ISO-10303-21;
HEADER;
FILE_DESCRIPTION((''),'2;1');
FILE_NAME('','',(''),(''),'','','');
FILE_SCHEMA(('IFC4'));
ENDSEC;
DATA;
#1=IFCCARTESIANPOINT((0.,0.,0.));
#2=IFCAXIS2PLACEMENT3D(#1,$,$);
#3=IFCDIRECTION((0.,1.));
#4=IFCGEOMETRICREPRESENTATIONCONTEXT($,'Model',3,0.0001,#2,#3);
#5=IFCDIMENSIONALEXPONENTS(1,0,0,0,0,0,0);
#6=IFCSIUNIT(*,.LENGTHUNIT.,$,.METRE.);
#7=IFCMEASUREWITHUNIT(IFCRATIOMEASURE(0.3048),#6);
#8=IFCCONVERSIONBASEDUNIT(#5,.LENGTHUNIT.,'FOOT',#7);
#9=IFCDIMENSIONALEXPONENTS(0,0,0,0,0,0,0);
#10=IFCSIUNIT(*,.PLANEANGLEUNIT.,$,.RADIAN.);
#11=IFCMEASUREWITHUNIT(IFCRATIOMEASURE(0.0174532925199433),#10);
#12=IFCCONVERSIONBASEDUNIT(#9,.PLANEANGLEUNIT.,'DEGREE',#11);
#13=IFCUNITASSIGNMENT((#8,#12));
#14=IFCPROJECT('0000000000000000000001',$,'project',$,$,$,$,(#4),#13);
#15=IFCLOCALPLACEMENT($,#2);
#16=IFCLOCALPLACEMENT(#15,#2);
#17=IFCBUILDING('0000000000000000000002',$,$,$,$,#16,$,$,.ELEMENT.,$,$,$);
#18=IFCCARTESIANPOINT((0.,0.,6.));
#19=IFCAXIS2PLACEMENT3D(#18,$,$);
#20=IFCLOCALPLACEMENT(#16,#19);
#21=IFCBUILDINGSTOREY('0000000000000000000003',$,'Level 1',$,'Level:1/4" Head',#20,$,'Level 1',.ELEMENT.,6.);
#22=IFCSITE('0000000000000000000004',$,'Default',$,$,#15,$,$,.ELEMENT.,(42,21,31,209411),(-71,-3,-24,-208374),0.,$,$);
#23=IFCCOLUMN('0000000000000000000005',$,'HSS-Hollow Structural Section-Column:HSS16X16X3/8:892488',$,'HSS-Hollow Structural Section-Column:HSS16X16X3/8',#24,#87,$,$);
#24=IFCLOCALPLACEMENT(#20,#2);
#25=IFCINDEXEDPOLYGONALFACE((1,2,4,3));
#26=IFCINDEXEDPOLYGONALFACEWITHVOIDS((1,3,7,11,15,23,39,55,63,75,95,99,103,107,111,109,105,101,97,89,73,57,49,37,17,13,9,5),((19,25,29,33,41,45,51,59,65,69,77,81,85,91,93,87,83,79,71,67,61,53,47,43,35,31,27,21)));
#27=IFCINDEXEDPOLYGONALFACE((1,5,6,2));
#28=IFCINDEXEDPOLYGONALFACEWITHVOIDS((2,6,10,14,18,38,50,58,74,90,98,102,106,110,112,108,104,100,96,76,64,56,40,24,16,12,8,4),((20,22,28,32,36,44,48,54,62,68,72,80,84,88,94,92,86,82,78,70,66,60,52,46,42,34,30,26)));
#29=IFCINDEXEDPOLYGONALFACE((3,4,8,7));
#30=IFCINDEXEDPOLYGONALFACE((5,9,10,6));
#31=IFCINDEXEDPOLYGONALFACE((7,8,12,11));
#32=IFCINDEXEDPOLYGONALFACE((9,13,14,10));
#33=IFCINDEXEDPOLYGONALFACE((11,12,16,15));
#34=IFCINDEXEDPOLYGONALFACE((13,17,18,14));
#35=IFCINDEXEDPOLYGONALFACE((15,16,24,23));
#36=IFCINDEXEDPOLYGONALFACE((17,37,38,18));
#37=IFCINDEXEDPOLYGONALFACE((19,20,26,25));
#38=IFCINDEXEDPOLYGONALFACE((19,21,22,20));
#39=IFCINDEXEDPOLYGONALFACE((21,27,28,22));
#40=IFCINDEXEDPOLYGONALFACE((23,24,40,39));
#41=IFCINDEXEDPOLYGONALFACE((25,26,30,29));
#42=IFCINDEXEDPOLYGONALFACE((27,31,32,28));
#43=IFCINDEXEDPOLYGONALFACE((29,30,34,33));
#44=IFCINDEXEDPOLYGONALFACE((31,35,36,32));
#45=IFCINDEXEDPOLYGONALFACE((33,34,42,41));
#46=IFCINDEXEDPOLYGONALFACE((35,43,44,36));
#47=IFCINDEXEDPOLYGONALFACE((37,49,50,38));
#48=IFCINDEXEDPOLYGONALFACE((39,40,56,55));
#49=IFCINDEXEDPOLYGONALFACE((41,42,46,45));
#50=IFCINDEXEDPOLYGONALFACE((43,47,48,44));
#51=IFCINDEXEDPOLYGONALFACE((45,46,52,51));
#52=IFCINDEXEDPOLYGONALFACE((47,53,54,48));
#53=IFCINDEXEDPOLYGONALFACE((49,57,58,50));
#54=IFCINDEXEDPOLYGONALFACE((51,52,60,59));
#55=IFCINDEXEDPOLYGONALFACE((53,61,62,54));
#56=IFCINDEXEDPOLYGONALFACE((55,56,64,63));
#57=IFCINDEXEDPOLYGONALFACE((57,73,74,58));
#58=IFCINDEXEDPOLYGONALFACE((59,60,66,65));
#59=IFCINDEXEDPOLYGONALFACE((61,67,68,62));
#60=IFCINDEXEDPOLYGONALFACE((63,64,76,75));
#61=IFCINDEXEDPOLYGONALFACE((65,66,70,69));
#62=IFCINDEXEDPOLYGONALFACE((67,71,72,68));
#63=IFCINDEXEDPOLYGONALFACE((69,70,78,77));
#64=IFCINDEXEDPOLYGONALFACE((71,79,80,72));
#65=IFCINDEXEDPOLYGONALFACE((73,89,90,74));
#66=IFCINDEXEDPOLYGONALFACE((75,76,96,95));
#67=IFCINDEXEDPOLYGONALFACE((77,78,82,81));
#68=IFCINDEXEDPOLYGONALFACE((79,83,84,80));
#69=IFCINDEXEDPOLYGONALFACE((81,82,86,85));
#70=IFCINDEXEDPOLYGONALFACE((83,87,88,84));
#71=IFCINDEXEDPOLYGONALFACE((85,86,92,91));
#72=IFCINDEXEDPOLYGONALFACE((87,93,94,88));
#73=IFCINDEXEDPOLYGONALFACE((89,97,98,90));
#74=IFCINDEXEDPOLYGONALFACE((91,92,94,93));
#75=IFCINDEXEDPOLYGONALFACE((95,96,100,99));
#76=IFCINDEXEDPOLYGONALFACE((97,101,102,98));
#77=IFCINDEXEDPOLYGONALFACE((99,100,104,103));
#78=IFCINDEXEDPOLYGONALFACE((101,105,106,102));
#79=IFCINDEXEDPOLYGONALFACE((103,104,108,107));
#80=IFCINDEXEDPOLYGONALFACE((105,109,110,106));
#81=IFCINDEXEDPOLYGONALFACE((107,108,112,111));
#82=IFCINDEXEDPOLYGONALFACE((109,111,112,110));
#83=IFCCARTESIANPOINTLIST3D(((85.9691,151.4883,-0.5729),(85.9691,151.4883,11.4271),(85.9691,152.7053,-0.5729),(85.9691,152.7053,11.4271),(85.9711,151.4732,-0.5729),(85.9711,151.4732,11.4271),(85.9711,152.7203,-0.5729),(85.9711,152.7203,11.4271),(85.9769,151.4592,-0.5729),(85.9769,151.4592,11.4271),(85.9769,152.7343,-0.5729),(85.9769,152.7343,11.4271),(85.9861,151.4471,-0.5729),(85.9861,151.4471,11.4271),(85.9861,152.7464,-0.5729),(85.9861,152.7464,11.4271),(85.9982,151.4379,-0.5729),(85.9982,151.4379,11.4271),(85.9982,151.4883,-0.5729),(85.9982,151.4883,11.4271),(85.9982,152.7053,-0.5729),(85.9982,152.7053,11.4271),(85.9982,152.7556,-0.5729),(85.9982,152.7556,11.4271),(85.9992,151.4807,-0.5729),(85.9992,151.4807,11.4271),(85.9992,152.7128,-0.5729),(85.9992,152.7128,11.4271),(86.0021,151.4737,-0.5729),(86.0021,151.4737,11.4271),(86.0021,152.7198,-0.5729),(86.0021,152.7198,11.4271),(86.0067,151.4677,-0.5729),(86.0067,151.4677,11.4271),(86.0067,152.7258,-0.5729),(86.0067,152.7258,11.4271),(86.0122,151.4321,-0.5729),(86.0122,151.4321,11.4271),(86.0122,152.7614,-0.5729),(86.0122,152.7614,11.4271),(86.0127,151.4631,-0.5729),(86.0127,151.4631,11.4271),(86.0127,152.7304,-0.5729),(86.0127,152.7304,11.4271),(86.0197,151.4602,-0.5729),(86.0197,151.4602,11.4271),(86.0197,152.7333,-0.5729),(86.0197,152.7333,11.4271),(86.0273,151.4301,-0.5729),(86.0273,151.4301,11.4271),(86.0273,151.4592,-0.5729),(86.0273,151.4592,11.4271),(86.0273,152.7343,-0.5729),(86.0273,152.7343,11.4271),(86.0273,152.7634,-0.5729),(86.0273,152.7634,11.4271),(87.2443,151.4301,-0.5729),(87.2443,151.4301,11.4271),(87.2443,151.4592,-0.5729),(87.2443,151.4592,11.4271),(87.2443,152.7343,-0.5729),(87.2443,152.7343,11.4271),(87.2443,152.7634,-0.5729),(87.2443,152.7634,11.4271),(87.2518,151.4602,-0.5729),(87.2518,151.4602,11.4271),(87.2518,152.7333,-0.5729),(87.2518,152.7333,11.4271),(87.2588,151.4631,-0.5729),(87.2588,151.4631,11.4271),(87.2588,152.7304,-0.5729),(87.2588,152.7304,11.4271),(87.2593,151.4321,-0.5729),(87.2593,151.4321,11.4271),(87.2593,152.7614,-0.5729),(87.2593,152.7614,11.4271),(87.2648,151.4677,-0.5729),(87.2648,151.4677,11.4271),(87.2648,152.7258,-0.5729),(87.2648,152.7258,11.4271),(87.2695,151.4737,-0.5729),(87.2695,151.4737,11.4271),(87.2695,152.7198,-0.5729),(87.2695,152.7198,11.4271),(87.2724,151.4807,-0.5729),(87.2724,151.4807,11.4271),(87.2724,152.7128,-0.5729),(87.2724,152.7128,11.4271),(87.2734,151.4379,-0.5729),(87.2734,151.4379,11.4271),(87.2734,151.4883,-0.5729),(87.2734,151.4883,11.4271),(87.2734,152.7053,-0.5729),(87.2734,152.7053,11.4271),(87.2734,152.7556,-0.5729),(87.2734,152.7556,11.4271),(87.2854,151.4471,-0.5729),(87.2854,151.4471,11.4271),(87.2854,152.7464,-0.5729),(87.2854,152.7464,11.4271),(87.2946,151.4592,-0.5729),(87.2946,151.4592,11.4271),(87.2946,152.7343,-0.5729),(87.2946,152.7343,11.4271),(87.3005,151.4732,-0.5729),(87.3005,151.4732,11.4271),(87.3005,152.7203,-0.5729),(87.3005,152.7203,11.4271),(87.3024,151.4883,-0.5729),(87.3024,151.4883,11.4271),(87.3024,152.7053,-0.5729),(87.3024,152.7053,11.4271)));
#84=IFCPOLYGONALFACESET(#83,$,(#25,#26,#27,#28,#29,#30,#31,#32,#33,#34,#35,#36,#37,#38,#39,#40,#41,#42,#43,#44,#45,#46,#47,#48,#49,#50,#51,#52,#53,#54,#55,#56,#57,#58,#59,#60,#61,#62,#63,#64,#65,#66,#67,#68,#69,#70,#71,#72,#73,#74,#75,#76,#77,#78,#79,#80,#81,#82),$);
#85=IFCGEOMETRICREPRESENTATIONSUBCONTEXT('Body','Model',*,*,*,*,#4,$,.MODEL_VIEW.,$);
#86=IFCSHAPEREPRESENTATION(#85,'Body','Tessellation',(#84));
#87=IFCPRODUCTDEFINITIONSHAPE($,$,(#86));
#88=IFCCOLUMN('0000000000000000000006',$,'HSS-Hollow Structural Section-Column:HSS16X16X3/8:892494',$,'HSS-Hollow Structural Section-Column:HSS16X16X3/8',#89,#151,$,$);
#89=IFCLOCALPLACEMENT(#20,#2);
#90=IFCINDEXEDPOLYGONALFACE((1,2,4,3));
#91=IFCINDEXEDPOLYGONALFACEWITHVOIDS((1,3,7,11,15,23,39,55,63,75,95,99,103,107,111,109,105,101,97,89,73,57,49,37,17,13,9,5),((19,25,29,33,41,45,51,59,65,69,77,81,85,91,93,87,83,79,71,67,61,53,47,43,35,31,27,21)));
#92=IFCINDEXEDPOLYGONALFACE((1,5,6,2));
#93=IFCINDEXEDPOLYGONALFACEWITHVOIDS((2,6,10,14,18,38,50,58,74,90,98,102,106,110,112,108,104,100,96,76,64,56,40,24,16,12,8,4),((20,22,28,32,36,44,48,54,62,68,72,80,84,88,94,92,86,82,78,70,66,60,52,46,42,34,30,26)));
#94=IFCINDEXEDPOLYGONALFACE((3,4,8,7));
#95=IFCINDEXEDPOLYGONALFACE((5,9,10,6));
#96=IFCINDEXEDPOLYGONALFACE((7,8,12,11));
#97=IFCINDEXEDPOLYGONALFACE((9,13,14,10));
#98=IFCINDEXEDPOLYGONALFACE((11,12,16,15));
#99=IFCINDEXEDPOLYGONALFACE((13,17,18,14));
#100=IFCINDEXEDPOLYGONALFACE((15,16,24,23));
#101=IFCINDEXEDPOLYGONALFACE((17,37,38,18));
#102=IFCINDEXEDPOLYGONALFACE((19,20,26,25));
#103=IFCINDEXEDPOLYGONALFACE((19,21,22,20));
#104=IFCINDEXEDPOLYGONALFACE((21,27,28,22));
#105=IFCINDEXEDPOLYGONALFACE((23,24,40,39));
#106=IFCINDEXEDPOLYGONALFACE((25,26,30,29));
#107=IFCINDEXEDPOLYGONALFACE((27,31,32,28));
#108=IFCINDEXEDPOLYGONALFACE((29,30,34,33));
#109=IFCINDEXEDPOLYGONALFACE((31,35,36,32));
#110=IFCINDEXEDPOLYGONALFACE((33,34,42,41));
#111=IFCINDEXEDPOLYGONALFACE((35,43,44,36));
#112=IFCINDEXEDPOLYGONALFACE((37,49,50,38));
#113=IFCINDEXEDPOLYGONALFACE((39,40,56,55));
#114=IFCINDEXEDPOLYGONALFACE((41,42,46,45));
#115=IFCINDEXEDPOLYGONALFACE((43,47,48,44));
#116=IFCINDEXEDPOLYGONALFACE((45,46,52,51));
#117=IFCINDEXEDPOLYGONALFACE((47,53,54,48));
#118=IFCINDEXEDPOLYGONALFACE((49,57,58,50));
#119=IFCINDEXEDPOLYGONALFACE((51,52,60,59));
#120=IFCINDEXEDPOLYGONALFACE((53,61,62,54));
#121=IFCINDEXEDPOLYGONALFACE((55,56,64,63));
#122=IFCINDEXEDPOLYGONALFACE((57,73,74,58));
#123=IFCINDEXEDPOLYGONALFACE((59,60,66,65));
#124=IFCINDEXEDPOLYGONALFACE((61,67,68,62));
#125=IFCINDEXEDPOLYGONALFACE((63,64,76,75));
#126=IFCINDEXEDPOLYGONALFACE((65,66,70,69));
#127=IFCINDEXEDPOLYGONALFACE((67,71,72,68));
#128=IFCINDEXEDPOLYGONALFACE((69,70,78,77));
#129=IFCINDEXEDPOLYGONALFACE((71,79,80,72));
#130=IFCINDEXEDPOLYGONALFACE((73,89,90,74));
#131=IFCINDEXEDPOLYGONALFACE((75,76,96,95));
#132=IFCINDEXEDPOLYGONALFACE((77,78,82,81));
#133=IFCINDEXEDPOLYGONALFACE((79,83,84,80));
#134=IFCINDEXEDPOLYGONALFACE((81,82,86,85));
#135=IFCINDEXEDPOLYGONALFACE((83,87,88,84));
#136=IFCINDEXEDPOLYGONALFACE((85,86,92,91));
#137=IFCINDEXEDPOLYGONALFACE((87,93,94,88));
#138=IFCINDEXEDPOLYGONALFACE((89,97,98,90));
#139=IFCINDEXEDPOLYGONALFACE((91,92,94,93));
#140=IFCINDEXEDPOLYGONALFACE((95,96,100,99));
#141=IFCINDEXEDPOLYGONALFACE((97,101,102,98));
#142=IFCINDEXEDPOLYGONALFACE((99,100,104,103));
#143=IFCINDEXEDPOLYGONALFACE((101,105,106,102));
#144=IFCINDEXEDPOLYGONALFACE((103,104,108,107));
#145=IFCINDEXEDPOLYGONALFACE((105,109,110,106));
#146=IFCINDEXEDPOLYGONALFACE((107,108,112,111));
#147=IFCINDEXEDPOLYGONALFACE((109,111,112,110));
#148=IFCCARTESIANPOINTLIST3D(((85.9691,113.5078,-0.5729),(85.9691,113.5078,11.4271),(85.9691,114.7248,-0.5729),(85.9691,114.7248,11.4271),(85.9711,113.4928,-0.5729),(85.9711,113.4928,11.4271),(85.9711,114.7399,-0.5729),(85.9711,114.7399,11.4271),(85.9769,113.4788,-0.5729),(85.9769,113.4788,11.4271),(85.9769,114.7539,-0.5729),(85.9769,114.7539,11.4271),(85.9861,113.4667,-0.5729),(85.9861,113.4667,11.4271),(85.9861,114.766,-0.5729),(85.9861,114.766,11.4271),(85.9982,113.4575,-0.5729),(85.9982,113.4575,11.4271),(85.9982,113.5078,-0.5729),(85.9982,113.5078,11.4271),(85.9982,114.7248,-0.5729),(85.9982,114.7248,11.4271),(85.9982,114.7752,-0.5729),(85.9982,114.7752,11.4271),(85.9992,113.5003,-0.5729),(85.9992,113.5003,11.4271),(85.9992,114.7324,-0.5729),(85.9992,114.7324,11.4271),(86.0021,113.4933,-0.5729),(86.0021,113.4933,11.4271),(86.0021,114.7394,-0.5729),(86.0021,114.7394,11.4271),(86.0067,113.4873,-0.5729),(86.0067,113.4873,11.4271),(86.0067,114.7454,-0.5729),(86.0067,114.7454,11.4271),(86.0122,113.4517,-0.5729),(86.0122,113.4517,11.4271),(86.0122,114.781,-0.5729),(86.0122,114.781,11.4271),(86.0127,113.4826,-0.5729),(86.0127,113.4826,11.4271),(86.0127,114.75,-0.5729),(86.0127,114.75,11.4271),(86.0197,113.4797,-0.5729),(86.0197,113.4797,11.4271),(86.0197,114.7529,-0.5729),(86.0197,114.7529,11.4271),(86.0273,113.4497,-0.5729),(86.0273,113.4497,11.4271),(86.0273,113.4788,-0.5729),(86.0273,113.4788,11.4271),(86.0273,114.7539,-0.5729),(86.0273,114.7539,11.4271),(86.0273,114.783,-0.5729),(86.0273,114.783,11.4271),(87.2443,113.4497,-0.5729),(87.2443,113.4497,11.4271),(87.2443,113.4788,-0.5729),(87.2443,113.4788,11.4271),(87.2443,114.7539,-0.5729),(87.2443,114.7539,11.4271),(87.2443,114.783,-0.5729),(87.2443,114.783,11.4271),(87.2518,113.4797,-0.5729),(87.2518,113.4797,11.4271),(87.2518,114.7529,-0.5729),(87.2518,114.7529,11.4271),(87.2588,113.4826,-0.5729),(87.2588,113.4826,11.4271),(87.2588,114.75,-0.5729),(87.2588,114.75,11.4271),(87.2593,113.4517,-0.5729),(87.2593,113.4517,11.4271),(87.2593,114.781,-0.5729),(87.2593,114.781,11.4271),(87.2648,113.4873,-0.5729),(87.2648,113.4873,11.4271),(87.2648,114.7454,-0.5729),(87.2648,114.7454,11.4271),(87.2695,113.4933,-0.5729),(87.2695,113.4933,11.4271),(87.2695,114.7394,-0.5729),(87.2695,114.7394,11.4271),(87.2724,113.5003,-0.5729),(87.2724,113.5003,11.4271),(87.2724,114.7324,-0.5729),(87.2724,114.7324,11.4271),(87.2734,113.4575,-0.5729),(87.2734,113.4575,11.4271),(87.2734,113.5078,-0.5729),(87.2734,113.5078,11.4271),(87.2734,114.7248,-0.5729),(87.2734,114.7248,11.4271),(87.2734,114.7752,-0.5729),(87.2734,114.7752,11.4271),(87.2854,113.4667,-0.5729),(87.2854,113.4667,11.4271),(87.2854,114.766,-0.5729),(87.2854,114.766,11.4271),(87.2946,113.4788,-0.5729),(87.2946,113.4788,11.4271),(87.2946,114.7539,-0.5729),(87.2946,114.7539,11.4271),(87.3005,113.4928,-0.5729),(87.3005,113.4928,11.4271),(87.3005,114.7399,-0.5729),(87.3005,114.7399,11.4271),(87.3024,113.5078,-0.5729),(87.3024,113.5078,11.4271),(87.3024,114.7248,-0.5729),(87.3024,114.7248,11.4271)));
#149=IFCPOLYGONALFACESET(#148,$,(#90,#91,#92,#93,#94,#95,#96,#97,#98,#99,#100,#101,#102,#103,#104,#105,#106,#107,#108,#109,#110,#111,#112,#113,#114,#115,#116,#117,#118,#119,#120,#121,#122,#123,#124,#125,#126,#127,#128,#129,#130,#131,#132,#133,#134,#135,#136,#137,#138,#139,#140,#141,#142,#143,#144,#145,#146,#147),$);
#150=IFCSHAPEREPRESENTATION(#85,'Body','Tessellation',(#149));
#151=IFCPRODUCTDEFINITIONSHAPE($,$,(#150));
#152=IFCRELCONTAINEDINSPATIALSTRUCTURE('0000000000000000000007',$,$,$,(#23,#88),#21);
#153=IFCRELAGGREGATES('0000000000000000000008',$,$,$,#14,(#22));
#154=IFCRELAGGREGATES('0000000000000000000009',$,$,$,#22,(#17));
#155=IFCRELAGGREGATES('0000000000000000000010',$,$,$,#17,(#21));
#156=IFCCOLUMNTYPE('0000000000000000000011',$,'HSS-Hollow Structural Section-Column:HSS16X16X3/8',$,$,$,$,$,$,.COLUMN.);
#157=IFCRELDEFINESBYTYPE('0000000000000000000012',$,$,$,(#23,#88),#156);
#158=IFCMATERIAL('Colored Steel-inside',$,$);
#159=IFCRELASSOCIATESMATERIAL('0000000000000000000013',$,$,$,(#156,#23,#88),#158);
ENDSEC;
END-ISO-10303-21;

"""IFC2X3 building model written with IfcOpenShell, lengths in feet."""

from ifc_helpers import new_model, entity, si_unit, converted_unit, direction, frame, frame_2d, origin, place, context, subcontext, project, spatial, polyline, circle_curve, parameter, trimmed, segment, composite_curve, outline, extrude, source, transform, mapped, material, type_object, type_shapes, element, save


model = new_model("IFC2X3")

# Units and contexts
model_context = context("Model", 3, precision=0.0001, world=origin(), true_north=direction((0.0, 1.0)))
body_context = subcontext(model_context, "Body", "Model", "MODEL_VIEW")
ifc_project = project(units=[converted_unit("LENGTHUNIT", "FOOT", entity("IfcRatioMeasure", 0.3048), si_unit("LENGTHUNIT", "METRE"), dimensions=[1, 0, 0, 0, 0, 0, 0]), converted_unit("PLANEANGLEUNIT", "DEGREE", entity("IfcRatioMeasure", 0.0174532925199433), si_unit("PLANEANGLEUNIT", "RADIAN"), dimensions=[0, 0, 0, 0, 0, 0, 0])], contexts=[model_context])

# Site, building, storey
site_placement = place(None, origin())
site = spatial("IfcSite", under=ifc_project, at=site_placement, Name="Default", CompositionType="ELEMENT", RefLatitude=(42, 21, 31, 209411), RefLongitude=(-71, -3, -24, -208374), RefElevation=0.0)
building_placement = place(site_placement, origin())
building = spatial("IfcBuilding", under=site, at=building_placement, CompositionType="ELEMENT")
storey_placement = place(building_placement, frame((0.0, 0.0, 6.0)))
storey = spatial("IfcBuildingStorey", under=building, at=storey_placement, Name="Level 1", ObjectType="Level:1/4\" Head", LongName="Level 1", CompositionType="ELEMENT", Elevation=6.0)

# Columns
ifc_material_1 = material(Name="Colored Steel-inside")
column_type_1 = type_object("IfcColumnType", Name="HSS-Hollow Structural Section-Column:HSS16X16X3/8", PredefinedType="COLUMN", material=ifc_material_1)
shared_shape_1 = source(origin(), body_context, "Body", "SweptSolid", [
    extrude(outline(composite_curve([segment(polyline([(-0.6085, -0.6667), (0.6085, -0.6667)]), True, "CONTINUOUS"), segment(trimmed(circle_curve(frame_2d((0.6085, -0.6085), x_axis=(-1.0, 0.0)), 0.0582), [parameter(90.0)], [parameter(180.0)], True, "PARAMETER"), True, "CONTINUOUS"), segment(polyline([(0.6667, -0.6085), (0.6667, 0.6085)]), True, "CONTINUOUS"), segment(trimmed(circle_curve(frame_2d((0.6085, 0.6085), x_axis=(-1.0, 0.0)), 0.0582), [parameter(180.0)], [parameter(270.0)], True, "PARAMETER"), True, "CONTINUOUS"), segment(polyline([(0.6085, 0.6667), (-0.6085, 0.6667)]), True, "CONTINUOUS"), segment(trimmed(circle_curve(frame_2d((-0.6085, 0.6085), x_axis=(-1.0, 0.0)), 0.0582), [parameter(270.0)], [parameter(360.0)], True, "PARAMETER"), True, "CONTINUOUS"), segment(polyline([(-0.6667, 0.6085), (-0.6667, -0.6085)]), True, "CONTINUOUS"), segment(trimmed(circle_curve(frame_2d((-0.6085, -0.6085), x_axis=(-1.0, 0.0)), 0.0582), [parameter(360.0)], [parameter(90.0)], True, "PARAMETER"), True, "CONTINUOUS")], self_intersect=False), holes=[composite_curve([segment(trimmed(circle_curve(frame_2d((-0.6085, -0.6085), x_axis=(-1.0, 0.0)), 0.0291), [parameter(0.0)], [parameter(90.0)], True, "PARAMETER"), False, "CONTINUOUS"), segment(polyline([(-0.6376, -0.6085), (-0.6376, 0.6085)]), True, "CONTINUOUS"), segment(trimmed(circle_curve(frame_2d((-0.6085, 0.6085), x_axis=(-1.0, 0.0)), 0.0291), [parameter(270.0)], [parameter(360.0)], True, "PARAMETER"), False, "CONTINUOUS"), segment(polyline([(-0.6085, 0.6376), (0.6085, 0.6376)]), True, "CONTINUOUS"), segment(trimmed(circle_curve(frame_2d((0.6085, 0.6085), x_axis=(-1.0, 0.0)), 0.0291), [parameter(180.0)], [parameter(270.0)], True, "PARAMETER"), False, "CONTINUOUS"), segment(polyline([(0.6376, 0.6085), (0.6376, -0.6085)]), True, "CONTINUOUS"), segment(trimmed(circle_curve(frame_2d((0.6085, -0.6085), x_axis=(-1.0, 0.0)), 0.0291), [parameter(90.0)], [parameter(180.0)], True, "PARAMETER"), False, "CONTINUOUS"), segment(polyline([(0.6085, -0.6376), (-0.6085, -0.6376)]), True, "CONTINUOUS")], self_intersect=False)]), frame((0.0, 0.0, 5.4271), z_axis=(0.0, 0.0, 1.0), x_axis=(-1.0, 0.0, 0.0)), (0.0, 0.0, 1.0), 12.0),
])
type_shapes(column_type_1, [shared_shape_1])
for number, where, name in (
    (1, (86.6358, 152.0968, -6.0), "HSS-Hollow Structural Section-Column:HSS16X16X3/8:892488"),
    (2, (86.6358, 114.1163, -6.0), "HSS-Hollow Structural Section-Column:HSS16X16X3/8:892494"),
):
    element("IfcColumn", number, at=place(storey_placement, frame(where)), inside=storey, type_object=column_type_1, material=ifc_material_1, Name=name, ObjectType="HSS-Hollow Structural Section-Column:HSS16X16X3/8", context=body_context, shape_type="MappedRepresentation", body=[
        mapped(shared_shape_1, transform((0.0, 0.0, 0.0), scale=1.0)),
    ])

save(model, "model.ifc")
